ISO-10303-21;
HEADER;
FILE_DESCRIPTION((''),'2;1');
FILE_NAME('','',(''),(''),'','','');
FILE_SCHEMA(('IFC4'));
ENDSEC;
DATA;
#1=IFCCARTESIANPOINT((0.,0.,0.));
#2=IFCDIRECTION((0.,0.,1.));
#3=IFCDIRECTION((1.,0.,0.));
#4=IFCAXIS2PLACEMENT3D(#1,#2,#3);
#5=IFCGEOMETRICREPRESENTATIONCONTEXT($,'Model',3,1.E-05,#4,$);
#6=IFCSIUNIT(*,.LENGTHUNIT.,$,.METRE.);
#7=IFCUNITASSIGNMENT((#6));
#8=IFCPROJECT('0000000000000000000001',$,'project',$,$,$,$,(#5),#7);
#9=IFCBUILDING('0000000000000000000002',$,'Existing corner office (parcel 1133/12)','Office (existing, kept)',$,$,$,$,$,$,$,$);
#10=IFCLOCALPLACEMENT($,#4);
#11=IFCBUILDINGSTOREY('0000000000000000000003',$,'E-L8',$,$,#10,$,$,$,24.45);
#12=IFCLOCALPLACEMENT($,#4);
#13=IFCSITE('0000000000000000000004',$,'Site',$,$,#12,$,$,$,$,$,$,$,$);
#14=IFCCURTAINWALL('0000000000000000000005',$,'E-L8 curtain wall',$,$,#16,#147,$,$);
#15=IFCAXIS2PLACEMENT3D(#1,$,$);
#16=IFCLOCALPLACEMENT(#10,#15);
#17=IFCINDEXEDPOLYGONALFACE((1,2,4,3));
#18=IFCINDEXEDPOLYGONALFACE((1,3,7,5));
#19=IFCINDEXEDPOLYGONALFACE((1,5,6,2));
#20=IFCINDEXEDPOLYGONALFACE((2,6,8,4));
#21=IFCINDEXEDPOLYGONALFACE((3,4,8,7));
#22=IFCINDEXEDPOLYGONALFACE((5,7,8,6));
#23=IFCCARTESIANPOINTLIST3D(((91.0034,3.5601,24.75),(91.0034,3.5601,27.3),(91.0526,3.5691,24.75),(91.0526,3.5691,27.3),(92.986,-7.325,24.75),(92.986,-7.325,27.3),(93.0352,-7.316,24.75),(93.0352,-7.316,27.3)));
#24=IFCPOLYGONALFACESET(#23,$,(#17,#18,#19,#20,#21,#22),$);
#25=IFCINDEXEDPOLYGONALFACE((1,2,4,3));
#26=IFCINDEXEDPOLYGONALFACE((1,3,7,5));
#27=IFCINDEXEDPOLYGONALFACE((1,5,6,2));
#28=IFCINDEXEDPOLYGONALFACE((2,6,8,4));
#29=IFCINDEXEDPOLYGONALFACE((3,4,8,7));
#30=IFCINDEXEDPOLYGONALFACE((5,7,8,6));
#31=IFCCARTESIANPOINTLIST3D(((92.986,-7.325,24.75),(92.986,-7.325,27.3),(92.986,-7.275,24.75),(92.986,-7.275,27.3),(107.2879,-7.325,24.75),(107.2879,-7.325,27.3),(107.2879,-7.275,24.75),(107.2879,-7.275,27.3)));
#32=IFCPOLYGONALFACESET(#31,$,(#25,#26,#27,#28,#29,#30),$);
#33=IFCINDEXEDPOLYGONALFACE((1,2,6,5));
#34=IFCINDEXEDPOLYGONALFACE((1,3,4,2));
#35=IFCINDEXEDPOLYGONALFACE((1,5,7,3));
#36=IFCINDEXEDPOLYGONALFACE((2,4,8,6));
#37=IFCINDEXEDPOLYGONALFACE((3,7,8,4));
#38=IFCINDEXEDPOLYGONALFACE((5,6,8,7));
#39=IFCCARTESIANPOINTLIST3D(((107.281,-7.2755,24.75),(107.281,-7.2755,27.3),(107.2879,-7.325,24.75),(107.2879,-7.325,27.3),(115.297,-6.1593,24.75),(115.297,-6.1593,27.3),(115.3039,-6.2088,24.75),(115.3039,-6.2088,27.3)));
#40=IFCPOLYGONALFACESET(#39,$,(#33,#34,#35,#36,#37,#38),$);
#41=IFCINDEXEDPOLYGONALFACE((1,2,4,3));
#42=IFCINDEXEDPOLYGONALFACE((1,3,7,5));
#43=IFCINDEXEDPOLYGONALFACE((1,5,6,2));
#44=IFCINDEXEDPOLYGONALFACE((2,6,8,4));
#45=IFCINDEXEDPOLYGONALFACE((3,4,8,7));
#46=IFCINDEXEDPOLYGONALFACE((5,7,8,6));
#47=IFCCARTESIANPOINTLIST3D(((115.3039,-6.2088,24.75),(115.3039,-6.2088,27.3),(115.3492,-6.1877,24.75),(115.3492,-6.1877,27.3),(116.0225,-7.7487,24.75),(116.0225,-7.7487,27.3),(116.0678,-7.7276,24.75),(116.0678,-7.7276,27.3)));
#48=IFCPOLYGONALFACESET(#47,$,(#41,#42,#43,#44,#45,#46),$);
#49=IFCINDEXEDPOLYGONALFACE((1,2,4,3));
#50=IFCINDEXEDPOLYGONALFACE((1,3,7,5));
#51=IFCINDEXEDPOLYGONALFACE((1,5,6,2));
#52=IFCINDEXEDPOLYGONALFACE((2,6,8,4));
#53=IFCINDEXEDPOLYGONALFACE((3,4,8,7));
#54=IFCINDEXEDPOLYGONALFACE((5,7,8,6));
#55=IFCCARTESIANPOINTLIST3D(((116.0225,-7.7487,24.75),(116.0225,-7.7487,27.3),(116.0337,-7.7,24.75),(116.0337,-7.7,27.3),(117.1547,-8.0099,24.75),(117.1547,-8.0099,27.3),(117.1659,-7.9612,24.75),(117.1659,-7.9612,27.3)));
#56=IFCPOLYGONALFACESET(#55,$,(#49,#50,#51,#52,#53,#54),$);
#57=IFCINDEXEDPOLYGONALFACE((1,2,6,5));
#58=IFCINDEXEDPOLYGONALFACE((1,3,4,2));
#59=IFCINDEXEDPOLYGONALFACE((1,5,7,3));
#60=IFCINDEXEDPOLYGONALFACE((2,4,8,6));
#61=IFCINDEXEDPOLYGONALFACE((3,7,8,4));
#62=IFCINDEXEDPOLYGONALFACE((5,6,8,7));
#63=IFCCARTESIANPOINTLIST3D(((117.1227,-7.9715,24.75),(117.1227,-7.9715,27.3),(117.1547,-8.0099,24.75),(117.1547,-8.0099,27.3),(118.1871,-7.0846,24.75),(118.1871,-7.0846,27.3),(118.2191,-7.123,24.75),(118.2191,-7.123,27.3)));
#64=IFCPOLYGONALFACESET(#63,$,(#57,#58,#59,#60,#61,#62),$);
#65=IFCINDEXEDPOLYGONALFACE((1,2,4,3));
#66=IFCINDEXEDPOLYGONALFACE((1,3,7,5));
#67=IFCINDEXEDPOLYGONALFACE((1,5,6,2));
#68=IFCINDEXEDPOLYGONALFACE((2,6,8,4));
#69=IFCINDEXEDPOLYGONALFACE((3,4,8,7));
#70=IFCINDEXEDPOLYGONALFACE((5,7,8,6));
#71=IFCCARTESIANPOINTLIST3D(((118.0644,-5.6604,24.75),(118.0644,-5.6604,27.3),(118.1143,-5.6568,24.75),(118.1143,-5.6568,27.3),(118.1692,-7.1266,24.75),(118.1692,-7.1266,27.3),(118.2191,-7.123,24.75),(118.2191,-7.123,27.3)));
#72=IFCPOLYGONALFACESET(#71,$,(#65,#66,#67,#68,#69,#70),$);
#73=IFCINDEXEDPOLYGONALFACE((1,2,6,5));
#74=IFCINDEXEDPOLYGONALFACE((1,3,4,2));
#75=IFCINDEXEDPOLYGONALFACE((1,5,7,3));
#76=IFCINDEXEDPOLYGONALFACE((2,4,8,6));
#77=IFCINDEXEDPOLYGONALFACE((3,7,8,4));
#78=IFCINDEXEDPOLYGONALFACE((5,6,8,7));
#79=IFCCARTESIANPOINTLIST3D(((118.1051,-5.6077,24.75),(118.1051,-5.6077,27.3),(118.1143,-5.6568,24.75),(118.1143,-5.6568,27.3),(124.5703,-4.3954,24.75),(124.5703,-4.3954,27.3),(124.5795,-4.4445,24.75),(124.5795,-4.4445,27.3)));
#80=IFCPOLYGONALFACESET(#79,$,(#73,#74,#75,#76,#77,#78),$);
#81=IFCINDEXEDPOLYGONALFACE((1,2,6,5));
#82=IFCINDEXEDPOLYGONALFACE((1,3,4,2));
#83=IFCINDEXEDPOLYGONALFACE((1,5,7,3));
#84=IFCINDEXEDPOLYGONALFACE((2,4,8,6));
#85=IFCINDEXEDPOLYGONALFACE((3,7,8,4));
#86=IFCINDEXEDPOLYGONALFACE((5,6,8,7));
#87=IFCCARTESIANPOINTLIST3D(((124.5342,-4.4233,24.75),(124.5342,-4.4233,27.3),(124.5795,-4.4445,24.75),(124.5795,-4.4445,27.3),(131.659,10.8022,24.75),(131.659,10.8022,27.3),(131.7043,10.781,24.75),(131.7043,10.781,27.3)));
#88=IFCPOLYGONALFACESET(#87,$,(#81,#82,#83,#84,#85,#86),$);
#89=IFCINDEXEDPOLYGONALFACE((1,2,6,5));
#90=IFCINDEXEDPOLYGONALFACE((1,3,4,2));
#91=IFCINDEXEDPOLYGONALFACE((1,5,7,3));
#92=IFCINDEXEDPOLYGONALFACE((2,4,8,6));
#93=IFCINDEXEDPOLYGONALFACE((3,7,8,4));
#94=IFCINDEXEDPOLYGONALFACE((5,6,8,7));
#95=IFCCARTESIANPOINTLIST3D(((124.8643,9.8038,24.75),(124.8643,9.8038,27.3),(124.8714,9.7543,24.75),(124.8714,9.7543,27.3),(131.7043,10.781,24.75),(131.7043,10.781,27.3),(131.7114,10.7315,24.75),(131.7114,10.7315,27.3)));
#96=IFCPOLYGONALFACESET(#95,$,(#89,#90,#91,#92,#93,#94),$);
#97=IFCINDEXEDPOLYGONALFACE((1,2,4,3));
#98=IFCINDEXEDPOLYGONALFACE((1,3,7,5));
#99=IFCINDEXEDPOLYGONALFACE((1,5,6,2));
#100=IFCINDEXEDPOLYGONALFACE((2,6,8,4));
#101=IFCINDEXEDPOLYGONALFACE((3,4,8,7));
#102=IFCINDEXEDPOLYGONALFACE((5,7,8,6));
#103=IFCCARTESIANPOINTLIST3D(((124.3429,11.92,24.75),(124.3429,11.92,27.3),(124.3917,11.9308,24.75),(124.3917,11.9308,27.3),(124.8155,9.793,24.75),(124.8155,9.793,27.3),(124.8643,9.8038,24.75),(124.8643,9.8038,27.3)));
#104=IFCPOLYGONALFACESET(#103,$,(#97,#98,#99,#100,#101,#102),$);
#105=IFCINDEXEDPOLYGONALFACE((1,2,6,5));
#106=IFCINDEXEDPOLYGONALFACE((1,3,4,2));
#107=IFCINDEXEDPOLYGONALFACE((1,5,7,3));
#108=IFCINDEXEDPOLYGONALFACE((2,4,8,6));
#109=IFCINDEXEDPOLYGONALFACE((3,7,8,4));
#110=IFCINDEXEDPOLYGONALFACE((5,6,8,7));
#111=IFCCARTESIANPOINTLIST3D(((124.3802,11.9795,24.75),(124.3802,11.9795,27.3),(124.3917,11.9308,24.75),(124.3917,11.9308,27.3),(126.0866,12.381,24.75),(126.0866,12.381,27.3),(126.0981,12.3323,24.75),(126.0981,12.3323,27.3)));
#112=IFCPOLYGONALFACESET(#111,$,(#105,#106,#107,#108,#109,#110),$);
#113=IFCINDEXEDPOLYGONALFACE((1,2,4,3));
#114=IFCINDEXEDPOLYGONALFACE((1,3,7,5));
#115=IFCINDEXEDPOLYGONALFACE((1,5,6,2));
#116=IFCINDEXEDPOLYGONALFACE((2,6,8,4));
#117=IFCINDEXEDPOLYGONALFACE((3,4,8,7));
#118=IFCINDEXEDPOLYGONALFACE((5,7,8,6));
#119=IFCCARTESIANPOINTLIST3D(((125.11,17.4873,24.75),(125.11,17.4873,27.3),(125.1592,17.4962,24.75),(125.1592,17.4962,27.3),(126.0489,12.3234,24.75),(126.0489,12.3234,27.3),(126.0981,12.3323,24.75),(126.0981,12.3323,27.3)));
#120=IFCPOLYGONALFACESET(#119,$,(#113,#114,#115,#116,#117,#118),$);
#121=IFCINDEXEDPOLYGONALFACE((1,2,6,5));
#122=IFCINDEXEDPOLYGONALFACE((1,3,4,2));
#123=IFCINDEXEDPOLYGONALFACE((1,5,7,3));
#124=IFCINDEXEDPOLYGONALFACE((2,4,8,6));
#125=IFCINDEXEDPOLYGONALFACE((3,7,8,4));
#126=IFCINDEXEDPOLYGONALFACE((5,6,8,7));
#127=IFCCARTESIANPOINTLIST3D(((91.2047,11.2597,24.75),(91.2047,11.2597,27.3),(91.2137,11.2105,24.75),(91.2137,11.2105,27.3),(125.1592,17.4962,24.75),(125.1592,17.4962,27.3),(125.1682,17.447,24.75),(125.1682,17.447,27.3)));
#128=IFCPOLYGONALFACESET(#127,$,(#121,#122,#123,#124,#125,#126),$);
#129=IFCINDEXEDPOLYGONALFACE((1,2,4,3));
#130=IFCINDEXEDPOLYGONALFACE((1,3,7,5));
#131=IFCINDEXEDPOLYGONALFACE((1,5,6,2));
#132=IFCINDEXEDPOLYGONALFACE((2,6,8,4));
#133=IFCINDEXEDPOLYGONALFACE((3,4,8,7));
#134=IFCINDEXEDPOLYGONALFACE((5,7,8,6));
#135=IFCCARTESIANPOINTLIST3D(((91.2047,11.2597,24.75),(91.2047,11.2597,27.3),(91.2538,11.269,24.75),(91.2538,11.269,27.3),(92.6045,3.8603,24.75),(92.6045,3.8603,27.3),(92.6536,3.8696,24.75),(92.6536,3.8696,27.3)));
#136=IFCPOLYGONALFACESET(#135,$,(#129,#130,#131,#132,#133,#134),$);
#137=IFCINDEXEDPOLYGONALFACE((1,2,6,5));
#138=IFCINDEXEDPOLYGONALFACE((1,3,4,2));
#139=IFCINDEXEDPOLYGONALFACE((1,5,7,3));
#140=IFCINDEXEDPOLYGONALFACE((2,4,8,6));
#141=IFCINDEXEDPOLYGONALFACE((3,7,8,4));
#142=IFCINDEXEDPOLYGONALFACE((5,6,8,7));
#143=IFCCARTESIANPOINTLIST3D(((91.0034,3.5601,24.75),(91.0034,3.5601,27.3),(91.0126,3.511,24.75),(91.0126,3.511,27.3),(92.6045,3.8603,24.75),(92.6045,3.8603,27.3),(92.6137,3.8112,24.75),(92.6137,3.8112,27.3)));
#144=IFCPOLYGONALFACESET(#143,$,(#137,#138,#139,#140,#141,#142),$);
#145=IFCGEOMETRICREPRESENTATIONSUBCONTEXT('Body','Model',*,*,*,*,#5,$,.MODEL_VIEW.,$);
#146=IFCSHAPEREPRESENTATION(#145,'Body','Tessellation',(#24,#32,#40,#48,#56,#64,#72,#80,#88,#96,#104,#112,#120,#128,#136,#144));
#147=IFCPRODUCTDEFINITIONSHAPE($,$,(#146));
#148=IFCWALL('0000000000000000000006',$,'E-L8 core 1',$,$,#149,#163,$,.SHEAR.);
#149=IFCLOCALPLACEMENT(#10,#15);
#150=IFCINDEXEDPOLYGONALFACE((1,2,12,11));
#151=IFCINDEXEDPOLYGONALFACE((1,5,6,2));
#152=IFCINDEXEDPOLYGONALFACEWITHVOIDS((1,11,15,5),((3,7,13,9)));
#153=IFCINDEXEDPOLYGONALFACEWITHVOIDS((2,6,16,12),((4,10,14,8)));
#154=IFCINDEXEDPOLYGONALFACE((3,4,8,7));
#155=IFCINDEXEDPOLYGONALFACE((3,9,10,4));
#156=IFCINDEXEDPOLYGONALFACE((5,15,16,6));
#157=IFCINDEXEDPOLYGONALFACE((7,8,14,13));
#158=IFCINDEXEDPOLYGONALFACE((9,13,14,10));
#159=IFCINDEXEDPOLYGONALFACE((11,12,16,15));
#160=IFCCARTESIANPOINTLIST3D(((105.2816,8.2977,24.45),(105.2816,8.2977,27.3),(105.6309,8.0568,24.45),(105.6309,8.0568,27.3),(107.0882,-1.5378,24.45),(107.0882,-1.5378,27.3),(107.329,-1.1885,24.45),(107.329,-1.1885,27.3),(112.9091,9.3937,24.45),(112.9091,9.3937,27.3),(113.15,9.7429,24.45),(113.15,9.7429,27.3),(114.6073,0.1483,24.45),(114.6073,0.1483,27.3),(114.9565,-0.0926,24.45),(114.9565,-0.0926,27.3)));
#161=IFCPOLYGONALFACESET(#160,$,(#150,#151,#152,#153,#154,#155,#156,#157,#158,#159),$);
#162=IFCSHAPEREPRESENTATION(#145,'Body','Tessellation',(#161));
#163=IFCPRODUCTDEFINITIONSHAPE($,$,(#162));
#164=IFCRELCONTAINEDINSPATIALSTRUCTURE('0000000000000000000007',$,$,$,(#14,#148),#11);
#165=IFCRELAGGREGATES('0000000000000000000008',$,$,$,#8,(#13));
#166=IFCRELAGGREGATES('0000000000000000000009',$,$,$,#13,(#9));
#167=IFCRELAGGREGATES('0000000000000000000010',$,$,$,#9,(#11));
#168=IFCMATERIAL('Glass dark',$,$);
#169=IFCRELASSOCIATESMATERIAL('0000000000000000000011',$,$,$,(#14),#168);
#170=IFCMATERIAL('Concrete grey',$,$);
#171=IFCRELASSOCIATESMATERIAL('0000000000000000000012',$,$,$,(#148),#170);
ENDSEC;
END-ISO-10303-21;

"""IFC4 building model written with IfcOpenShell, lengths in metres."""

from ifc_helpers import new_model, si_unit, frame, origin_with_axes, place, context, subcontext, project, spatial, polyline, outline, extrude, material, element, save


model = new_model("IFC4")

# Units and contexts
model_context = context("Model", 3, precision=1e-05, world=origin_with_axes())
body_context = subcontext(model_context, "Body", "Model", "MODEL_VIEW")
ifc_project = project(units=[si_unit("LENGTHUNIT", "METRE")], contexts=[model_context])

# Site, building, storey
site_placement = place(None, origin_with_axes())
site = spatial("IfcSite", under=ifc_project, at=site_placement, Name="Site")
building = spatial("IfcBuilding", under=site, Name="Existing corner office (parcel 1133/12)", Description="Office (existing, kept)")
storey_placement = place(None, origin_with_axes())
storey = spatial("IfcBuildingStorey", under=building, at=storey_placement, Name="E-L8", Elevation=24.45)

# Shared definitions
ifc_material_1 = material(Name="Concrete grey")

# Curtain wall
ifc_material_2 = material(Name="Glass dark")
curtain_wall_placement = place(storey_placement, origin_with_axes())
element("IfcCurtainWall", 1, at=curtain_wall_placement, inside=storey, material=ifc_material_2, Name="E-L8 curtain wall", context=body_context, shape_type="SweptSolid", body=[
    extrude(outline(polyline([(91.0034, 3.5601), (92.986, -7.325), (93.0352, -7.316), (91.0526, 3.5691), (91.0034, 3.5601)])), frame((0.0, 0.0, 24.75), z_axis=(0.0, 0.0, 1.0), x_axis=(1.0, 0.0, 0.0)), (0.0, 0.0, 1.0), 2.55),
    extrude(outline(polyline([(92.986, -7.325), (107.2879, -7.325), (107.2879, -7.275), (92.986, -7.275), (92.986, -7.325)])), frame((0.0, 0.0, 24.75), z_axis=(0.0, 0.0, 1.0), x_axis=(1.0, 0.0, 0.0)), (0.0, 0.0, 1.0), 2.55),
    extrude(outline(polyline([(107.2879, -7.325), (115.3039, -6.2088), (115.297, -6.1593), (107.281, -7.2755), (107.2879, -7.325)])), frame((0.0, 0.0, 24.75), z_axis=(0.0, 0.0, 1.0), x_axis=(1.0, 0.0, 0.0)), (0.0, 0.0, 1.0), 2.55),
    extrude(outline(polyline([(115.3039, -6.2088), (116.0225, -7.7487), (116.0678, -7.7276), (115.3492, -6.1877), (115.3039, -6.2088)])), frame((0.0, 0.0, 24.75), z_axis=(0.0, 0.0, 1.0), x_axis=(1.0, 0.0, 0.0)), (0.0, 0.0, 1.0), 2.55),
    extrude(outline(polyline([(116.0225, -7.7487), (117.1547, -8.0099), (117.1659, -7.9612), (116.0337, -7.7), (116.0225, -7.7487)])), frame((0.0, 0.0, 24.75), z_axis=(0.0, 0.0, 1.0), x_axis=(1.0, 0.0, 0.0)), (0.0, 0.0, 1.0), 2.55),
    extrude(outline(polyline([(117.1547, -8.0099), (118.2191, -7.123), (118.1871, -7.0846), (117.1227, -7.9715), (117.1547, -8.0099)])), frame((0.0, 0.0, 24.75), z_axis=(0.0, 0.0, 1.0), x_axis=(1.0, 0.0, 0.0)), (0.0, 0.0, 1.0), 2.55),
    extrude(outline(polyline([(118.2191, -7.123), (118.1143, -5.6568), (118.0644, -5.6604), (118.1692, -7.1266), (118.2191, -7.123)])), frame((0.0, 0.0, 24.75), z_axis=(0.0, 0.0, 1.0), x_axis=(1.0, 0.0, 0.0)), (0.0, 0.0, 1.0), 2.55),
    extrude(outline(polyline([(118.1143, -5.6568), (124.5795, -4.4445), (124.5703, -4.3954), (118.1051, -5.6077), (118.1143, -5.6568)])), frame((0.0, 0.0, 24.75), z_axis=(0.0, 0.0, 1.0), x_axis=(1.0, 0.0, 0.0)), (0.0, 0.0, 1.0), 2.55),
    extrude(outline(polyline([(124.5795, -4.4445), (131.7043, 10.781), (131.659, 10.8022), (124.5342, -4.4233), (124.5795, -4.4445)])), frame((0.0, 0.0, 24.75), z_axis=(0.0, 0.0, 1.0), x_axis=(1.0, 0.0, 0.0)), (0.0, 0.0, 1.0), 2.55),
    extrude(outline(polyline([(131.7043, 10.781), (124.8643, 9.8038), (124.8714, 9.7543), (131.7114, 10.7315), (131.7043, 10.781)])), frame((0.0, 0.0, 24.75), z_axis=(0.0, 0.0, 1.0), x_axis=(1.0, 0.0, 0.0)), (0.0, 0.0, 1.0), 2.55),
    extrude(outline(polyline([(124.8643, 9.8038), (124.3917, 11.9308), (124.3429, 11.92), (124.8155, 9.793), (124.8643, 9.8038)])), frame((0.0, 0.0, 24.75), z_axis=(0.0, 0.0, 1.0), x_axis=(1.0, 0.0, 0.0)), (0.0, 0.0, 1.0), 2.55),
    extrude(outline(polyline([(124.3917, 11.9308), (126.0981, 12.3323), (126.0866, 12.381), (124.3802, 11.9795), (124.3917, 11.9308)])), frame((0.0, 0.0, 24.75), z_axis=(0.0, 0.0, 1.0), x_axis=(1.0, 0.0, 0.0)), (0.0, 0.0, 1.0), 2.55),
    extrude(outline(polyline([(126.0981, 12.3323), (125.1592, 17.4962), (125.11, 17.4873), (126.0489, 12.3234), (126.0981, 12.3323)])), frame((0.0, 0.0, 24.75), z_axis=(0.0, 0.0, 1.0), x_axis=(1.0, 0.0, 0.0)), (0.0, 0.0, 1.0), 2.55),
    extrude(outline(polyline([(125.1592, 17.4962), (91.2047, 11.2597), (91.2137, 11.2105), (125.1682, 17.447), (125.1592, 17.4962)])), frame((0.0, 0.0, 24.75), z_axis=(0.0, 0.0, 1.0), x_axis=(1.0, 0.0, 0.0)), (0.0, 0.0, 1.0), 2.55),
    extrude(outline(polyline([(91.2047, 11.2597), (92.6045, 3.8603), (92.6536, 3.8696), (91.2538, 11.269), (91.2047, 11.2597)])), frame((0.0, 0.0, 24.75), z_axis=(0.0, 0.0, 1.0), x_axis=(1.0, 0.0, 0.0)), (0.0, 0.0, 1.0), 2.55),
    extrude(outline(polyline([(92.6045, 3.8603), (91.0034, 3.5601), (91.0126, 3.511), (92.6137, 3.8112), (92.6045, 3.8603)])), frame((0.0, 0.0, 24.75), z_axis=(0.0, 0.0, 1.0), x_axis=(1.0, 0.0, 0.0)), (0.0, 0.0, 1.0), 2.55),
])

# Wall
wall_placement = place(storey_placement, origin_with_axes())
element("IfcWall", 2, at=wall_placement, inside=storey, material=ifc_material_1, Name="E-L8 core 1", PredefinedType="SHEAR", context=body_context, shape_type="SweptSolid", body=[
    extrude(outline(polyline([(113.15, 9.7429), (105.2816, 8.2977), (107.0882, -1.5378), (114.9565, -0.0926), (113.15, 9.7429)]), holes=[polyline([(112.9091, 9.3937), (105.6309, 8.0568), (107.329, -1.1885), (114.6073, 0.1483), (112.9091, 9.3937)])]), frame((0.0, 0.0, 24.45), z_axis=(0.0, 0.0, 1.0), x_axis=(1.0, 0.0, 0.0)), (0.0, 0.0, 1.0), 2.85),
])

save(model, "model.ifc")
